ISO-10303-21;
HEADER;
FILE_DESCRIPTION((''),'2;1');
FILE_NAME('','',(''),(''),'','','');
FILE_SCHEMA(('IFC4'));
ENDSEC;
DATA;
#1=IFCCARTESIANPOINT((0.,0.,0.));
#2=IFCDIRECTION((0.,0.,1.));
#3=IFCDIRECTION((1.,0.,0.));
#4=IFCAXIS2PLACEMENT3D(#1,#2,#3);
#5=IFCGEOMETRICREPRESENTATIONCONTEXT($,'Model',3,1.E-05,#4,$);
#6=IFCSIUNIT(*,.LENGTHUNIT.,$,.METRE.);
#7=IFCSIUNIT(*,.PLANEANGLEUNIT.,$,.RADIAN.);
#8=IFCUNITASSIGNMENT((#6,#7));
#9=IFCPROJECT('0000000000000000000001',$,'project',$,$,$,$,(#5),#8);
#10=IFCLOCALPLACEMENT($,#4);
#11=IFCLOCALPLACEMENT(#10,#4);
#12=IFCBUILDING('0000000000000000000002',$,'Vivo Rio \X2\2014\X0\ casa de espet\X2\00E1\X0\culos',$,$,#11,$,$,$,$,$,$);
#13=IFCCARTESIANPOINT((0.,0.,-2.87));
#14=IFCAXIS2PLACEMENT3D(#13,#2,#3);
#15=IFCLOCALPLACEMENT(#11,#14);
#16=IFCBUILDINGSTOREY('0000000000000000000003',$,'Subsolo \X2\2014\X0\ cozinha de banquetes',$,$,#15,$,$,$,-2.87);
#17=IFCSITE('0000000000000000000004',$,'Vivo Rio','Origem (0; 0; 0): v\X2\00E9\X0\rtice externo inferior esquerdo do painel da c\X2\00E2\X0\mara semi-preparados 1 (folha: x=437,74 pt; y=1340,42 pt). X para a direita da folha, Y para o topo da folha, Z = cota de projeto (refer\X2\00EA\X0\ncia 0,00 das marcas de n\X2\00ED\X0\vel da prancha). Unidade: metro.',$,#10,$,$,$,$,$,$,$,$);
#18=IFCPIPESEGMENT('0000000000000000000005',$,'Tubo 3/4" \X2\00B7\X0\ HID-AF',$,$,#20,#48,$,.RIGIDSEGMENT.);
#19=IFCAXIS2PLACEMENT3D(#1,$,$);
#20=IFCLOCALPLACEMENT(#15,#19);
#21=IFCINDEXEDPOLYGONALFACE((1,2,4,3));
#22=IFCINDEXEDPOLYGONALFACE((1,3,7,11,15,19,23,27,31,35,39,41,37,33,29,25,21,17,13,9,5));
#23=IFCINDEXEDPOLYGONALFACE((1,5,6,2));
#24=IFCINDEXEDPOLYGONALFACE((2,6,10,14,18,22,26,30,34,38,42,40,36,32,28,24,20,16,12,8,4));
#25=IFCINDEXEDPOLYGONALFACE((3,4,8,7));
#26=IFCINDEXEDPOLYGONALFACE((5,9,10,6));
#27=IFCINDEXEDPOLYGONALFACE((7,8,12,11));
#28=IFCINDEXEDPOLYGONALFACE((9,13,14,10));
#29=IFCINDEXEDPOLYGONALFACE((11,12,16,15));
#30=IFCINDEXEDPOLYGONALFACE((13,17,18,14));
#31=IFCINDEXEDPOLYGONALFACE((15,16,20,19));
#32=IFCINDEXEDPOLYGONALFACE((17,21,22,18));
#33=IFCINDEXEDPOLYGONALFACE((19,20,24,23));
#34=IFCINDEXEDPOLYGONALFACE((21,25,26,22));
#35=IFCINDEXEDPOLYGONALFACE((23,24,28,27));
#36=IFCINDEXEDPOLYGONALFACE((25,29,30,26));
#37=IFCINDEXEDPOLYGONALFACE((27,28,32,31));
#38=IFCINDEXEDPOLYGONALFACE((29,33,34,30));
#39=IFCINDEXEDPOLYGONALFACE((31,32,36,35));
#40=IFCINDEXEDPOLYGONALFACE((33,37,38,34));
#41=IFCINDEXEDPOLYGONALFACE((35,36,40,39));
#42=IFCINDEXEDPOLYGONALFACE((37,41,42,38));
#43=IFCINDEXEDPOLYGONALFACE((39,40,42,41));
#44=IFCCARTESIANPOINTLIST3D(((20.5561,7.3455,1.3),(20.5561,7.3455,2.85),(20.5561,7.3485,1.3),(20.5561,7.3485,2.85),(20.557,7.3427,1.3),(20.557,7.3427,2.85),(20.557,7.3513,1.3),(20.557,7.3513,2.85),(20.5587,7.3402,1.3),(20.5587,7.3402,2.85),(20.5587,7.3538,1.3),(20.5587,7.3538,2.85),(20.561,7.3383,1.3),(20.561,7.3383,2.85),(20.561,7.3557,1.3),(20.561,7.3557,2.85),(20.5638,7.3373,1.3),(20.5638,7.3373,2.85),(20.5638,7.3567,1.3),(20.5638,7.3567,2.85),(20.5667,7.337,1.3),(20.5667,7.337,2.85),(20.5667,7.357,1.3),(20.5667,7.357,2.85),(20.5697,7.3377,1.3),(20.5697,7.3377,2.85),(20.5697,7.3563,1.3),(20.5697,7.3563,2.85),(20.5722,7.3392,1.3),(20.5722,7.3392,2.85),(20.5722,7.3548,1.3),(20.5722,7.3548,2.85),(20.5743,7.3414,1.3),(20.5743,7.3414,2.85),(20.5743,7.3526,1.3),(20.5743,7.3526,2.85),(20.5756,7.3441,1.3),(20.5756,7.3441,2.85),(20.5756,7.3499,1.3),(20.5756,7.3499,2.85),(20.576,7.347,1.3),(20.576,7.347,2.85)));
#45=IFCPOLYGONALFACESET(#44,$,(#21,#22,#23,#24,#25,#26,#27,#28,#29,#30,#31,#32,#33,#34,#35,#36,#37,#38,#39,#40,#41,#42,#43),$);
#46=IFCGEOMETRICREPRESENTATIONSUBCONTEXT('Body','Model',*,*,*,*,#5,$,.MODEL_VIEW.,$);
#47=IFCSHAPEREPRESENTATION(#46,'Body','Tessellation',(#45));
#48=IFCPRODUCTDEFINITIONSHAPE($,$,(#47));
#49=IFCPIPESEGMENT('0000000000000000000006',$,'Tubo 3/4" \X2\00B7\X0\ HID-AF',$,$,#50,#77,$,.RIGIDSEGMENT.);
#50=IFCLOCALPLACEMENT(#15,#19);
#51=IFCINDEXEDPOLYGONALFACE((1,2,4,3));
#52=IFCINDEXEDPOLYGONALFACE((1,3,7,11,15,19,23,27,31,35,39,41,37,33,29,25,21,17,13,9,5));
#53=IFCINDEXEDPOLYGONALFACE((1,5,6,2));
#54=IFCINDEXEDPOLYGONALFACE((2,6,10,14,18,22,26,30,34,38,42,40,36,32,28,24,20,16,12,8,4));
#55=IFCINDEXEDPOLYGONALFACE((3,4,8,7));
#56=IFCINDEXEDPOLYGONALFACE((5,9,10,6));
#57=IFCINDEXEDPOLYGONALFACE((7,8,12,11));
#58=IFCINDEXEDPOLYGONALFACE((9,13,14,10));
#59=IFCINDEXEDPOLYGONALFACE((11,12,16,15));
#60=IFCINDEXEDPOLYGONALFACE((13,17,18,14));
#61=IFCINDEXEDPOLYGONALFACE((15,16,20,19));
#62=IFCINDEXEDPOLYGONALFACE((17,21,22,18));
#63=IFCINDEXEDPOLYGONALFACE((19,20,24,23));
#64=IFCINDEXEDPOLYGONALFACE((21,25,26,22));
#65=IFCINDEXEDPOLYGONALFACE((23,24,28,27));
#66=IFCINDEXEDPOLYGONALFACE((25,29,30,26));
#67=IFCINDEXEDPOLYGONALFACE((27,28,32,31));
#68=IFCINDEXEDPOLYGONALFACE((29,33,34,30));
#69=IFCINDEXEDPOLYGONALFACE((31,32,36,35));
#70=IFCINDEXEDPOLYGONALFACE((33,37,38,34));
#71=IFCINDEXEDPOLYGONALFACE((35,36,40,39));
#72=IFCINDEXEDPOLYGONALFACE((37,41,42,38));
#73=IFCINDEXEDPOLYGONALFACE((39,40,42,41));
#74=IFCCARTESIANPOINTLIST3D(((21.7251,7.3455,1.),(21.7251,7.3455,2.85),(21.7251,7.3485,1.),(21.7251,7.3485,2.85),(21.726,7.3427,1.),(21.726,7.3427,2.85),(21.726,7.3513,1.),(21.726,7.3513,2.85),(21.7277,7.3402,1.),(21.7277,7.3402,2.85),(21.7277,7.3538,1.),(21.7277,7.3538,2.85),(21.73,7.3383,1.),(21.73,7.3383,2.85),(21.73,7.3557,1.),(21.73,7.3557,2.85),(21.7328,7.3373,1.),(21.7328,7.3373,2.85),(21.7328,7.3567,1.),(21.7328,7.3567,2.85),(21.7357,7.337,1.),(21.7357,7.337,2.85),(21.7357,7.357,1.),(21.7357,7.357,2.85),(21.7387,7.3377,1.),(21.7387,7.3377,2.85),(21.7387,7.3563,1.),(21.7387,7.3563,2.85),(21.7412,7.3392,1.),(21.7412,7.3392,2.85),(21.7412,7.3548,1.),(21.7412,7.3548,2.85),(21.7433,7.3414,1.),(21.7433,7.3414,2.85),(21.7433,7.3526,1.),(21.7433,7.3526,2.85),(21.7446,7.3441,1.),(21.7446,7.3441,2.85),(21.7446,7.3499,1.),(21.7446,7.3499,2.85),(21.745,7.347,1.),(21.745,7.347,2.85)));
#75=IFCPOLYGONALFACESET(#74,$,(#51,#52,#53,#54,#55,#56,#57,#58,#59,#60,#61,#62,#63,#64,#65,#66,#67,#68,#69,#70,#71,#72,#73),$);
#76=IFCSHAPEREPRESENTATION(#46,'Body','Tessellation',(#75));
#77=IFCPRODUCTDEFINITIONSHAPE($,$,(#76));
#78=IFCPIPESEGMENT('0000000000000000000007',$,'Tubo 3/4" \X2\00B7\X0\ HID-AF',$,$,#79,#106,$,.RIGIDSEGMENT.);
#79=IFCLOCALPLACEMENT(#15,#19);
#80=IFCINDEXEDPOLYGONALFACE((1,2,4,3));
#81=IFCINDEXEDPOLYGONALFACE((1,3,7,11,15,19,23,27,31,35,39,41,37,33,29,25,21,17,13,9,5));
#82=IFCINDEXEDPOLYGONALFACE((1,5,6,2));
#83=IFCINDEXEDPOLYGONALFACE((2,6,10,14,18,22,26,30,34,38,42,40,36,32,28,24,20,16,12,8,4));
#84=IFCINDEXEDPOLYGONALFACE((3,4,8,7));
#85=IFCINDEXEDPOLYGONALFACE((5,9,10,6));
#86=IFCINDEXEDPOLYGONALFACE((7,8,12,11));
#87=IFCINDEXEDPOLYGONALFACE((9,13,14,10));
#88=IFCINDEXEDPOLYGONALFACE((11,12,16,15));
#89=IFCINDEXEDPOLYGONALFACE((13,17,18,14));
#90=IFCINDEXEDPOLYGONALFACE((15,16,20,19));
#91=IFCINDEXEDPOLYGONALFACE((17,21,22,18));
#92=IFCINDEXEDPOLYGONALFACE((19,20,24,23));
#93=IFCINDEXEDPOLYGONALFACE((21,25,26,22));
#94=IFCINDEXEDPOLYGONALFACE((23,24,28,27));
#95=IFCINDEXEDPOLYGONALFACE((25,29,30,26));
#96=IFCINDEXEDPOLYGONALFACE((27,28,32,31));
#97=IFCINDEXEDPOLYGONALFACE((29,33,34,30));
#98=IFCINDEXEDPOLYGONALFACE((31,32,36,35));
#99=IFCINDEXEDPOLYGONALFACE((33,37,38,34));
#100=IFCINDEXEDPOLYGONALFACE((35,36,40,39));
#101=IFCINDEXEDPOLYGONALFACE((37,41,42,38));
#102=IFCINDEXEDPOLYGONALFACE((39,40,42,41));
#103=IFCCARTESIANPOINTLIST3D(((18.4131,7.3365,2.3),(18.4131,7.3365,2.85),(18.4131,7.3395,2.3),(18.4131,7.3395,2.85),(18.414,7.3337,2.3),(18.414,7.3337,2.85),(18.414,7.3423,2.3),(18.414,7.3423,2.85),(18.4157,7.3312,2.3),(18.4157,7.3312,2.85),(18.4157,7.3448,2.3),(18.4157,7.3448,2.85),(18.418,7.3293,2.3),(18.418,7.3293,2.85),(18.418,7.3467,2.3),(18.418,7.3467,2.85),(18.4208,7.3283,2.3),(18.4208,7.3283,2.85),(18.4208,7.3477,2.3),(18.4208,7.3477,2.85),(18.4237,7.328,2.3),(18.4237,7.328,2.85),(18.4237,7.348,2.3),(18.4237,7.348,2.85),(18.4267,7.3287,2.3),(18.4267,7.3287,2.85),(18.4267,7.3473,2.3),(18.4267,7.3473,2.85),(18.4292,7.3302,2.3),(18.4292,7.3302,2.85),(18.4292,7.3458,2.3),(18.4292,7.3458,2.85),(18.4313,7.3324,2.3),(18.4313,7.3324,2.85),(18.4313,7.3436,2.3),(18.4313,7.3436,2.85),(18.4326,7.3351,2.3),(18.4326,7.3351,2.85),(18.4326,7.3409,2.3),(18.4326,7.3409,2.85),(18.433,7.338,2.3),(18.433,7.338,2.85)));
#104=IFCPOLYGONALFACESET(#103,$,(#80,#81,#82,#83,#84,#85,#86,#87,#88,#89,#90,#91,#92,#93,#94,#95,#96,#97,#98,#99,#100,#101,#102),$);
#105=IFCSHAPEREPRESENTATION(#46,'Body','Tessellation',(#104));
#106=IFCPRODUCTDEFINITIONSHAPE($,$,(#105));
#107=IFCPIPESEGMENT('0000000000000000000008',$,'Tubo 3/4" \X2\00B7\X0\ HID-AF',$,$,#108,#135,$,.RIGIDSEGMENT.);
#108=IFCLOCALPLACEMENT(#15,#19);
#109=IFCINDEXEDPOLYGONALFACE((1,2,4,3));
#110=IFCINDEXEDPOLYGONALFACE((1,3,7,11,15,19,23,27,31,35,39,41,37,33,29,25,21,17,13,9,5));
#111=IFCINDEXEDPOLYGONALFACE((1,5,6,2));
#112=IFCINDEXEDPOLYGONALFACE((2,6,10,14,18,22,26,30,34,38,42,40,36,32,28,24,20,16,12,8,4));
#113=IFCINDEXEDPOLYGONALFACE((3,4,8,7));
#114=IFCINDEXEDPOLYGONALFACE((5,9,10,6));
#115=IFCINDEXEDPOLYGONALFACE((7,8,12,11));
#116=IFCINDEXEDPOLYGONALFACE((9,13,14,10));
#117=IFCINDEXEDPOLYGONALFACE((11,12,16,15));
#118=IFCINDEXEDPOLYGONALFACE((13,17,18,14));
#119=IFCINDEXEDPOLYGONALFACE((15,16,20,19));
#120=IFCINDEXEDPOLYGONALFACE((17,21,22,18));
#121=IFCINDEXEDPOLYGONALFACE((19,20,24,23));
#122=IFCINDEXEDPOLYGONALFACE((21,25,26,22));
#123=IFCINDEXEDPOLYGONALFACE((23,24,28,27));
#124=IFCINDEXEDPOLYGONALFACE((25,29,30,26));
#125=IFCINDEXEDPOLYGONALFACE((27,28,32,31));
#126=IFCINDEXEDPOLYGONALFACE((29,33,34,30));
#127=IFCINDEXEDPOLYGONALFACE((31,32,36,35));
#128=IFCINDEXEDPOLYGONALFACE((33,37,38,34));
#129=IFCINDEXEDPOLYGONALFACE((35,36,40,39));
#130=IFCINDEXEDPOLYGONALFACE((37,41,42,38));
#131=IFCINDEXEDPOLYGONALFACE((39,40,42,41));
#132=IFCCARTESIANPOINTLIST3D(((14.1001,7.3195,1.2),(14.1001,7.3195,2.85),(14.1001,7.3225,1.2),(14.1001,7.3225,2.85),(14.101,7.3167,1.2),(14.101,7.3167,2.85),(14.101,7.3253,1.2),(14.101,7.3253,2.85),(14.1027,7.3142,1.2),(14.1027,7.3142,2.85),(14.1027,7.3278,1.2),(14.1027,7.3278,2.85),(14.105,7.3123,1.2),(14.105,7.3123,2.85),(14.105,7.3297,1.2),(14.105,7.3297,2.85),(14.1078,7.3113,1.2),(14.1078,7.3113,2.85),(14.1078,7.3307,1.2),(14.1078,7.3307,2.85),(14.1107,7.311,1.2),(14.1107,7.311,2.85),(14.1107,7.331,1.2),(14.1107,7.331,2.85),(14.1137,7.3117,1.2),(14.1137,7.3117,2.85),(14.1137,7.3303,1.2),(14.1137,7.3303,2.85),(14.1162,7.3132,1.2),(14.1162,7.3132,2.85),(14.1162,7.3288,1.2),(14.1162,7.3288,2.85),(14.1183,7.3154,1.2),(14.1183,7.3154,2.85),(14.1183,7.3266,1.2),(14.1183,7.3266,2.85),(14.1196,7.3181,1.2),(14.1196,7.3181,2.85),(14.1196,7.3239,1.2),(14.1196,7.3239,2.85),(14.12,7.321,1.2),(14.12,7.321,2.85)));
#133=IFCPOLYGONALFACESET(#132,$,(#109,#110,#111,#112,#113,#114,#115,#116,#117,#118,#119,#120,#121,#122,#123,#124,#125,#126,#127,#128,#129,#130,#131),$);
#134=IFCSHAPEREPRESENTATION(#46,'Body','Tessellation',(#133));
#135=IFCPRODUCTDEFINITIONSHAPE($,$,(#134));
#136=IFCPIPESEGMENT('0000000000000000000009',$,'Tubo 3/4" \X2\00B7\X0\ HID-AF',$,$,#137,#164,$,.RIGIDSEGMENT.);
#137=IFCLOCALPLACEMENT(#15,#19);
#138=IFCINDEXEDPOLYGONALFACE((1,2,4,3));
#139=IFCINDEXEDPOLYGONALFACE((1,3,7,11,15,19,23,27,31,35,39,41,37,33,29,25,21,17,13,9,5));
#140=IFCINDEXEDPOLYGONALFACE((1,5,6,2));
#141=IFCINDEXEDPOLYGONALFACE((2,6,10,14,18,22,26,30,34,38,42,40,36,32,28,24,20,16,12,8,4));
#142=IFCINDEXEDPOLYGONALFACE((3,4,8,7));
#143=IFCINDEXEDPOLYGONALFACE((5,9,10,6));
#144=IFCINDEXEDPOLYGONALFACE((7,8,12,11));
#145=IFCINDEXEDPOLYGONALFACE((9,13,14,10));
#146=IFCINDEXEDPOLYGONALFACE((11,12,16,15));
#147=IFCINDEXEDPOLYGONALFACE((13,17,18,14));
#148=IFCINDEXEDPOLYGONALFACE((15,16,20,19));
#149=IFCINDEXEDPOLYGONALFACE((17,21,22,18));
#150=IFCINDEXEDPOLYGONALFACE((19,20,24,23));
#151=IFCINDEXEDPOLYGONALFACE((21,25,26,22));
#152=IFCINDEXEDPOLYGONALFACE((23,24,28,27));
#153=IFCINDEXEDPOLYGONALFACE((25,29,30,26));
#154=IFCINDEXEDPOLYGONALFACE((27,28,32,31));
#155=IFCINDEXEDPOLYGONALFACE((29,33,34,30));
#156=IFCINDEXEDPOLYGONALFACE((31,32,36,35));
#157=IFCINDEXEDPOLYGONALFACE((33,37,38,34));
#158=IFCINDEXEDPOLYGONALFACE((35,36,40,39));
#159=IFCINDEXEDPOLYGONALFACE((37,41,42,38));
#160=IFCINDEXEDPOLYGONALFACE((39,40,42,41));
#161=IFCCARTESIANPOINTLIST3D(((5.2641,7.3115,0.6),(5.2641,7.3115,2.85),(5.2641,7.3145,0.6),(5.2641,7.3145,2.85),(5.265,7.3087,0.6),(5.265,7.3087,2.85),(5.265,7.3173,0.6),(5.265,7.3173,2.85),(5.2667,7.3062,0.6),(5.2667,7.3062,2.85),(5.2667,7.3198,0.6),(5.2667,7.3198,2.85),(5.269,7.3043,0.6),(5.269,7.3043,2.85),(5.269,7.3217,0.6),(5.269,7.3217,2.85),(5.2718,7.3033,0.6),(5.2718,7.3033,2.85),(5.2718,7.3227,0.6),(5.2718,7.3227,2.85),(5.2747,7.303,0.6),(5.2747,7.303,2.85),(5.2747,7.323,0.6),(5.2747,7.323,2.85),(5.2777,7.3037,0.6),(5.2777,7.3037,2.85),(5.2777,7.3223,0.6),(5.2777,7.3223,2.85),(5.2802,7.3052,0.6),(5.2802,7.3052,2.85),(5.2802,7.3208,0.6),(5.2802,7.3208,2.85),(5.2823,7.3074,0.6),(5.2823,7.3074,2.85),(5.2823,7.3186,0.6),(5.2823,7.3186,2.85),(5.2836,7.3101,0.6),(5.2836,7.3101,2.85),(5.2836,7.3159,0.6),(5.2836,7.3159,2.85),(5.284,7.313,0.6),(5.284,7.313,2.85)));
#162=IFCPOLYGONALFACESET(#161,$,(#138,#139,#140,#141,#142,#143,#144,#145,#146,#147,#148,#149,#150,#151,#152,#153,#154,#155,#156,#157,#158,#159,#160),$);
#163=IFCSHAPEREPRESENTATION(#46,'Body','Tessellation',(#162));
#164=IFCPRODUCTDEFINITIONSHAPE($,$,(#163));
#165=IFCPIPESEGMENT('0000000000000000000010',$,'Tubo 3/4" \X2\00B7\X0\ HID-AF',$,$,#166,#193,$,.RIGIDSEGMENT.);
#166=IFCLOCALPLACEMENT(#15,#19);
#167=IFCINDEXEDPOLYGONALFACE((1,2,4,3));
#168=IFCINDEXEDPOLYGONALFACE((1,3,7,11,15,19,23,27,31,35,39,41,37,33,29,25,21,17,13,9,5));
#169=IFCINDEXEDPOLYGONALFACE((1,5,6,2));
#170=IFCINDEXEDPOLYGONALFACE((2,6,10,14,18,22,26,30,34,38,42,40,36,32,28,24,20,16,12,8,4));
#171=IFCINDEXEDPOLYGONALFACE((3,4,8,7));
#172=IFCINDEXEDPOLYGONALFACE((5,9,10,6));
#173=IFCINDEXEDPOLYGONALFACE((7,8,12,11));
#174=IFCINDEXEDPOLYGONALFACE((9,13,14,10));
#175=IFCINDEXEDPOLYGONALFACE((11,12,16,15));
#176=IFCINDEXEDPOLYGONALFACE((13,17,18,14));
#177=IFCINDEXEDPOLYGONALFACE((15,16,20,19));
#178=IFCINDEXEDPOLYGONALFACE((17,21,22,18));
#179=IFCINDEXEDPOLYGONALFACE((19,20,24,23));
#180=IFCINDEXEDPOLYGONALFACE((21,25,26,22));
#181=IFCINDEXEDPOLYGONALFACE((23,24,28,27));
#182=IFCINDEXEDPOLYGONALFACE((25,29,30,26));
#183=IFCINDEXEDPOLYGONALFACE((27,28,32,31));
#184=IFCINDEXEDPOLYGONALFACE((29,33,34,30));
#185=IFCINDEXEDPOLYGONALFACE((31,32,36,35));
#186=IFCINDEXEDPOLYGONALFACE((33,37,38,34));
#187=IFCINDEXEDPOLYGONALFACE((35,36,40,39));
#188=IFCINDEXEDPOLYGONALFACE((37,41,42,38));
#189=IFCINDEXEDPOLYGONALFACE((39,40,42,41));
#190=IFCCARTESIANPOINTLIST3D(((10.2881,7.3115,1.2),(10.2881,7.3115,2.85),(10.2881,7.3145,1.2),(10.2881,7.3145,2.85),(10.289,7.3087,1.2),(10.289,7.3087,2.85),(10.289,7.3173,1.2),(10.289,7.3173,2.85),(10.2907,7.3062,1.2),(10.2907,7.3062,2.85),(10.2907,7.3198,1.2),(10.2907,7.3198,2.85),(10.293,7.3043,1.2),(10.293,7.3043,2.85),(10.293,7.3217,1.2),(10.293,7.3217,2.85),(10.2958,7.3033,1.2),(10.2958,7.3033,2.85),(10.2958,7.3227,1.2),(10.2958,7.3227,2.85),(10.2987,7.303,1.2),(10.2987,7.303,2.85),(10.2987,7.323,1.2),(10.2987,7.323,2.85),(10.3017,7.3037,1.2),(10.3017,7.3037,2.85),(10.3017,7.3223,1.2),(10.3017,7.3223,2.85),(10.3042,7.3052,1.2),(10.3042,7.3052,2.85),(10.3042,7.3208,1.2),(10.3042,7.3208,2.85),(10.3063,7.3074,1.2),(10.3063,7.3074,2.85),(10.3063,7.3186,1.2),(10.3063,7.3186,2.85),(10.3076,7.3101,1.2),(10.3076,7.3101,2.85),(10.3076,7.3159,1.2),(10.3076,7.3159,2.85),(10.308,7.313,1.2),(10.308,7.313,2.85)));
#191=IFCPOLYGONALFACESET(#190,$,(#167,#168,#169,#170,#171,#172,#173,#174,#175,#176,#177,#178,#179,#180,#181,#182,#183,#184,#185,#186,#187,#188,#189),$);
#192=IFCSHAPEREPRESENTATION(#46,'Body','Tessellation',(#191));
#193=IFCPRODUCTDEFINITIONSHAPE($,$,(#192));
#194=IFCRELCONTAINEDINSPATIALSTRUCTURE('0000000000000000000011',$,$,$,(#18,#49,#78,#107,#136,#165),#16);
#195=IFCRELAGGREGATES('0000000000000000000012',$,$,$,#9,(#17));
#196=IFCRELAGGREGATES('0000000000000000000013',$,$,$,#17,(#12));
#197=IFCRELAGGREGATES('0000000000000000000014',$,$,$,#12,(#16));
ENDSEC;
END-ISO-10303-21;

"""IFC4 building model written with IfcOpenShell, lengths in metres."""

from ifc_helpers import new_model, si_unit, frame, origin_with_axes, origin_2d, place, context, subcontext, project, spatial, circle, extrude, element, save


model = new_model("IFC4")

# Units and contexts
model_context = context("Model", 3, precision=1e-05, world=origin_with_axes())
body_context = subcontext(model_context, "Body", "Model", "MODEL_VIEW")
ifc_project = project(units=[si_unit("LENGTHUNIT", "METRE"), si_unit("PLANEANGLEUNIT", "RADIAN")], contexts=[model_context])

# Site, building, storey
site_placement = place(None, origin_with_axes())
site = spatial("IfcSite", under=ifc_project, at=site_placement, Name="Vivo Rio", Description="Origem (0; 0; 0): vértice externo inferior esquerdo do painel da câmara semi-preparados 1 (folha: x=437,74 pt; y=1340,42 pt). X para a direita da folha, Y para o topo da folha, Z = cota de projeto (referência 0,00 das marcas de nível da prancha). Unidade: metro.")
building_placement = place(site_placement, origin_with_axes())
building = spatial("IfcBuilding", under=site, at=building_placement, Name="Vivo Rio — casa de espetáculos")
storey_placement = place(building_placement, frame((0.0, 0.0, -2.87), z_axis=(0.0, 0.0, 1.0), x_axis=(1.0, 0.0, 0.0)))
storey = spatial("IfcBuildingStorey", under=building, at=storey_placement, Name="Subsolo — cozinha de banquetes", Elevation=-2.87)

# Pipe segments
pipe_segment_1_placement = place(storey_placement, origin_with_axes())
element("IfcPipeSegment", 1, at=pipe_segment_1_placement, inside=storey, Name="Tubo 3/4\" · HID-AF", PredefinedType="RIGIDSEGMENT", context=body_context, shape_type="SweptSolid", body=[
    extrude(circle(Radius=0.01, at=origin_2d()), frame((20.566, 7.347, 2.85), z_axis=(0.0, 0.0, -1.0), x_axis=(1.0, 0.0, 0.0)), (0.0, 0.0, 1.0), 1.55),
])
pipe_segment_2_placement = place(storey_placement, origin_with_axes())
element("IfcPipeSegment", 2, at=pipe_segment_2_placement, inside=storey, Name="Tubo 3/4\" · HID-AF", PredefinedType="RIGIDSEGMENT", context=body_context, shape_type="SweptSolid", body=[
    extrude(circle(Radius=0.01, at=origin_2d()), frame((21.735, 7.347, 2.85), z_axis=(0.0, 0.0, -1.0), x_axis=(1.0, 0.0, 0.0)), (0.0, 0.0, 1.0), 1.85),
])
pipe_segment_3_placement = place(storey_placement, origin_with_axes())
element("IfcPipeSegment", 3, at=pipe_segment_3_placement, inside=storey, Name="Tubo 3/4\" · HID-AF", PredefinedType="RIGIDSEGMENT", context=body_context, shape_type="SweptSolid", body=[
    extrude(circle(Radius=0.01, at=origin_2d()), frame((18.423, 7.338, 2.85), z_axis=(0.0, 0.0, -1.0), x_axis=(1.0, 0.0, 0.0)), (0.0, 0.0, 1.0), 0.55),
])
pipe_segment_4_placement = place(storey_placement, origin_with_axes())
element("IfcPipeSegment", 4, at=pipe_segment_4_placement, inside=storey, Name="Tubo 3/4\" · HID-AF", PredefinedType="RIGIDSEGMENT", context=body_context, shape_type="SweptSolid", body=[
    extrude(circle(Radius=0.01, at=origin_2d()), frame((14.11, 7.321, 2.85), z_axis=(0.0, 0.0, -1.0), x_axis=(1.0, 0.0, 0.0)), (0.0, 0.0, 1.0), 1.65),
])
pipe_segment_5_placement = place(storey_placement, origin_with_axes())
element("IfcPipeSegment", 5, at=pipe_segment_5_placement, inside=storey, Name="Tubo 3/4\" · HID-AF", PredefinedType="RIGIDSEGMENT", context=body_context, shape_type="SweptSolid", body=[
    extrude(circle(Radius=0.01, at=origin_2d()), frame((5.274, 7.313, 2.85), z_axis=(0.0, 0.0, -1.0), x_axis=(1.0, 0.0, 0.0)), (0.0, 0.0, 1.0), 2.25),
])
pipe_segment_6_placement = place(storey_placement, origin_with_axes())
element("IfcPipeSegment", 6, at=pipe_segment_6_placement, inside=storey, Name="Tubo 3/4\" · HID-AF", PredefinedType="RIGIDSEGMENT", context=body_context, shape_type="SweptSolid", body=[
    extrude(circle(Radius=0.01, at=origin_2d()), frame((10.298, 7.313, 2.85), z_axis=(0.0, 0.0, -1.0), x_axis=(1.0, 0.0, 0.0)), (0.0, 0.0, 1.0), 1.65),
])

save(model, "model.ifc")
